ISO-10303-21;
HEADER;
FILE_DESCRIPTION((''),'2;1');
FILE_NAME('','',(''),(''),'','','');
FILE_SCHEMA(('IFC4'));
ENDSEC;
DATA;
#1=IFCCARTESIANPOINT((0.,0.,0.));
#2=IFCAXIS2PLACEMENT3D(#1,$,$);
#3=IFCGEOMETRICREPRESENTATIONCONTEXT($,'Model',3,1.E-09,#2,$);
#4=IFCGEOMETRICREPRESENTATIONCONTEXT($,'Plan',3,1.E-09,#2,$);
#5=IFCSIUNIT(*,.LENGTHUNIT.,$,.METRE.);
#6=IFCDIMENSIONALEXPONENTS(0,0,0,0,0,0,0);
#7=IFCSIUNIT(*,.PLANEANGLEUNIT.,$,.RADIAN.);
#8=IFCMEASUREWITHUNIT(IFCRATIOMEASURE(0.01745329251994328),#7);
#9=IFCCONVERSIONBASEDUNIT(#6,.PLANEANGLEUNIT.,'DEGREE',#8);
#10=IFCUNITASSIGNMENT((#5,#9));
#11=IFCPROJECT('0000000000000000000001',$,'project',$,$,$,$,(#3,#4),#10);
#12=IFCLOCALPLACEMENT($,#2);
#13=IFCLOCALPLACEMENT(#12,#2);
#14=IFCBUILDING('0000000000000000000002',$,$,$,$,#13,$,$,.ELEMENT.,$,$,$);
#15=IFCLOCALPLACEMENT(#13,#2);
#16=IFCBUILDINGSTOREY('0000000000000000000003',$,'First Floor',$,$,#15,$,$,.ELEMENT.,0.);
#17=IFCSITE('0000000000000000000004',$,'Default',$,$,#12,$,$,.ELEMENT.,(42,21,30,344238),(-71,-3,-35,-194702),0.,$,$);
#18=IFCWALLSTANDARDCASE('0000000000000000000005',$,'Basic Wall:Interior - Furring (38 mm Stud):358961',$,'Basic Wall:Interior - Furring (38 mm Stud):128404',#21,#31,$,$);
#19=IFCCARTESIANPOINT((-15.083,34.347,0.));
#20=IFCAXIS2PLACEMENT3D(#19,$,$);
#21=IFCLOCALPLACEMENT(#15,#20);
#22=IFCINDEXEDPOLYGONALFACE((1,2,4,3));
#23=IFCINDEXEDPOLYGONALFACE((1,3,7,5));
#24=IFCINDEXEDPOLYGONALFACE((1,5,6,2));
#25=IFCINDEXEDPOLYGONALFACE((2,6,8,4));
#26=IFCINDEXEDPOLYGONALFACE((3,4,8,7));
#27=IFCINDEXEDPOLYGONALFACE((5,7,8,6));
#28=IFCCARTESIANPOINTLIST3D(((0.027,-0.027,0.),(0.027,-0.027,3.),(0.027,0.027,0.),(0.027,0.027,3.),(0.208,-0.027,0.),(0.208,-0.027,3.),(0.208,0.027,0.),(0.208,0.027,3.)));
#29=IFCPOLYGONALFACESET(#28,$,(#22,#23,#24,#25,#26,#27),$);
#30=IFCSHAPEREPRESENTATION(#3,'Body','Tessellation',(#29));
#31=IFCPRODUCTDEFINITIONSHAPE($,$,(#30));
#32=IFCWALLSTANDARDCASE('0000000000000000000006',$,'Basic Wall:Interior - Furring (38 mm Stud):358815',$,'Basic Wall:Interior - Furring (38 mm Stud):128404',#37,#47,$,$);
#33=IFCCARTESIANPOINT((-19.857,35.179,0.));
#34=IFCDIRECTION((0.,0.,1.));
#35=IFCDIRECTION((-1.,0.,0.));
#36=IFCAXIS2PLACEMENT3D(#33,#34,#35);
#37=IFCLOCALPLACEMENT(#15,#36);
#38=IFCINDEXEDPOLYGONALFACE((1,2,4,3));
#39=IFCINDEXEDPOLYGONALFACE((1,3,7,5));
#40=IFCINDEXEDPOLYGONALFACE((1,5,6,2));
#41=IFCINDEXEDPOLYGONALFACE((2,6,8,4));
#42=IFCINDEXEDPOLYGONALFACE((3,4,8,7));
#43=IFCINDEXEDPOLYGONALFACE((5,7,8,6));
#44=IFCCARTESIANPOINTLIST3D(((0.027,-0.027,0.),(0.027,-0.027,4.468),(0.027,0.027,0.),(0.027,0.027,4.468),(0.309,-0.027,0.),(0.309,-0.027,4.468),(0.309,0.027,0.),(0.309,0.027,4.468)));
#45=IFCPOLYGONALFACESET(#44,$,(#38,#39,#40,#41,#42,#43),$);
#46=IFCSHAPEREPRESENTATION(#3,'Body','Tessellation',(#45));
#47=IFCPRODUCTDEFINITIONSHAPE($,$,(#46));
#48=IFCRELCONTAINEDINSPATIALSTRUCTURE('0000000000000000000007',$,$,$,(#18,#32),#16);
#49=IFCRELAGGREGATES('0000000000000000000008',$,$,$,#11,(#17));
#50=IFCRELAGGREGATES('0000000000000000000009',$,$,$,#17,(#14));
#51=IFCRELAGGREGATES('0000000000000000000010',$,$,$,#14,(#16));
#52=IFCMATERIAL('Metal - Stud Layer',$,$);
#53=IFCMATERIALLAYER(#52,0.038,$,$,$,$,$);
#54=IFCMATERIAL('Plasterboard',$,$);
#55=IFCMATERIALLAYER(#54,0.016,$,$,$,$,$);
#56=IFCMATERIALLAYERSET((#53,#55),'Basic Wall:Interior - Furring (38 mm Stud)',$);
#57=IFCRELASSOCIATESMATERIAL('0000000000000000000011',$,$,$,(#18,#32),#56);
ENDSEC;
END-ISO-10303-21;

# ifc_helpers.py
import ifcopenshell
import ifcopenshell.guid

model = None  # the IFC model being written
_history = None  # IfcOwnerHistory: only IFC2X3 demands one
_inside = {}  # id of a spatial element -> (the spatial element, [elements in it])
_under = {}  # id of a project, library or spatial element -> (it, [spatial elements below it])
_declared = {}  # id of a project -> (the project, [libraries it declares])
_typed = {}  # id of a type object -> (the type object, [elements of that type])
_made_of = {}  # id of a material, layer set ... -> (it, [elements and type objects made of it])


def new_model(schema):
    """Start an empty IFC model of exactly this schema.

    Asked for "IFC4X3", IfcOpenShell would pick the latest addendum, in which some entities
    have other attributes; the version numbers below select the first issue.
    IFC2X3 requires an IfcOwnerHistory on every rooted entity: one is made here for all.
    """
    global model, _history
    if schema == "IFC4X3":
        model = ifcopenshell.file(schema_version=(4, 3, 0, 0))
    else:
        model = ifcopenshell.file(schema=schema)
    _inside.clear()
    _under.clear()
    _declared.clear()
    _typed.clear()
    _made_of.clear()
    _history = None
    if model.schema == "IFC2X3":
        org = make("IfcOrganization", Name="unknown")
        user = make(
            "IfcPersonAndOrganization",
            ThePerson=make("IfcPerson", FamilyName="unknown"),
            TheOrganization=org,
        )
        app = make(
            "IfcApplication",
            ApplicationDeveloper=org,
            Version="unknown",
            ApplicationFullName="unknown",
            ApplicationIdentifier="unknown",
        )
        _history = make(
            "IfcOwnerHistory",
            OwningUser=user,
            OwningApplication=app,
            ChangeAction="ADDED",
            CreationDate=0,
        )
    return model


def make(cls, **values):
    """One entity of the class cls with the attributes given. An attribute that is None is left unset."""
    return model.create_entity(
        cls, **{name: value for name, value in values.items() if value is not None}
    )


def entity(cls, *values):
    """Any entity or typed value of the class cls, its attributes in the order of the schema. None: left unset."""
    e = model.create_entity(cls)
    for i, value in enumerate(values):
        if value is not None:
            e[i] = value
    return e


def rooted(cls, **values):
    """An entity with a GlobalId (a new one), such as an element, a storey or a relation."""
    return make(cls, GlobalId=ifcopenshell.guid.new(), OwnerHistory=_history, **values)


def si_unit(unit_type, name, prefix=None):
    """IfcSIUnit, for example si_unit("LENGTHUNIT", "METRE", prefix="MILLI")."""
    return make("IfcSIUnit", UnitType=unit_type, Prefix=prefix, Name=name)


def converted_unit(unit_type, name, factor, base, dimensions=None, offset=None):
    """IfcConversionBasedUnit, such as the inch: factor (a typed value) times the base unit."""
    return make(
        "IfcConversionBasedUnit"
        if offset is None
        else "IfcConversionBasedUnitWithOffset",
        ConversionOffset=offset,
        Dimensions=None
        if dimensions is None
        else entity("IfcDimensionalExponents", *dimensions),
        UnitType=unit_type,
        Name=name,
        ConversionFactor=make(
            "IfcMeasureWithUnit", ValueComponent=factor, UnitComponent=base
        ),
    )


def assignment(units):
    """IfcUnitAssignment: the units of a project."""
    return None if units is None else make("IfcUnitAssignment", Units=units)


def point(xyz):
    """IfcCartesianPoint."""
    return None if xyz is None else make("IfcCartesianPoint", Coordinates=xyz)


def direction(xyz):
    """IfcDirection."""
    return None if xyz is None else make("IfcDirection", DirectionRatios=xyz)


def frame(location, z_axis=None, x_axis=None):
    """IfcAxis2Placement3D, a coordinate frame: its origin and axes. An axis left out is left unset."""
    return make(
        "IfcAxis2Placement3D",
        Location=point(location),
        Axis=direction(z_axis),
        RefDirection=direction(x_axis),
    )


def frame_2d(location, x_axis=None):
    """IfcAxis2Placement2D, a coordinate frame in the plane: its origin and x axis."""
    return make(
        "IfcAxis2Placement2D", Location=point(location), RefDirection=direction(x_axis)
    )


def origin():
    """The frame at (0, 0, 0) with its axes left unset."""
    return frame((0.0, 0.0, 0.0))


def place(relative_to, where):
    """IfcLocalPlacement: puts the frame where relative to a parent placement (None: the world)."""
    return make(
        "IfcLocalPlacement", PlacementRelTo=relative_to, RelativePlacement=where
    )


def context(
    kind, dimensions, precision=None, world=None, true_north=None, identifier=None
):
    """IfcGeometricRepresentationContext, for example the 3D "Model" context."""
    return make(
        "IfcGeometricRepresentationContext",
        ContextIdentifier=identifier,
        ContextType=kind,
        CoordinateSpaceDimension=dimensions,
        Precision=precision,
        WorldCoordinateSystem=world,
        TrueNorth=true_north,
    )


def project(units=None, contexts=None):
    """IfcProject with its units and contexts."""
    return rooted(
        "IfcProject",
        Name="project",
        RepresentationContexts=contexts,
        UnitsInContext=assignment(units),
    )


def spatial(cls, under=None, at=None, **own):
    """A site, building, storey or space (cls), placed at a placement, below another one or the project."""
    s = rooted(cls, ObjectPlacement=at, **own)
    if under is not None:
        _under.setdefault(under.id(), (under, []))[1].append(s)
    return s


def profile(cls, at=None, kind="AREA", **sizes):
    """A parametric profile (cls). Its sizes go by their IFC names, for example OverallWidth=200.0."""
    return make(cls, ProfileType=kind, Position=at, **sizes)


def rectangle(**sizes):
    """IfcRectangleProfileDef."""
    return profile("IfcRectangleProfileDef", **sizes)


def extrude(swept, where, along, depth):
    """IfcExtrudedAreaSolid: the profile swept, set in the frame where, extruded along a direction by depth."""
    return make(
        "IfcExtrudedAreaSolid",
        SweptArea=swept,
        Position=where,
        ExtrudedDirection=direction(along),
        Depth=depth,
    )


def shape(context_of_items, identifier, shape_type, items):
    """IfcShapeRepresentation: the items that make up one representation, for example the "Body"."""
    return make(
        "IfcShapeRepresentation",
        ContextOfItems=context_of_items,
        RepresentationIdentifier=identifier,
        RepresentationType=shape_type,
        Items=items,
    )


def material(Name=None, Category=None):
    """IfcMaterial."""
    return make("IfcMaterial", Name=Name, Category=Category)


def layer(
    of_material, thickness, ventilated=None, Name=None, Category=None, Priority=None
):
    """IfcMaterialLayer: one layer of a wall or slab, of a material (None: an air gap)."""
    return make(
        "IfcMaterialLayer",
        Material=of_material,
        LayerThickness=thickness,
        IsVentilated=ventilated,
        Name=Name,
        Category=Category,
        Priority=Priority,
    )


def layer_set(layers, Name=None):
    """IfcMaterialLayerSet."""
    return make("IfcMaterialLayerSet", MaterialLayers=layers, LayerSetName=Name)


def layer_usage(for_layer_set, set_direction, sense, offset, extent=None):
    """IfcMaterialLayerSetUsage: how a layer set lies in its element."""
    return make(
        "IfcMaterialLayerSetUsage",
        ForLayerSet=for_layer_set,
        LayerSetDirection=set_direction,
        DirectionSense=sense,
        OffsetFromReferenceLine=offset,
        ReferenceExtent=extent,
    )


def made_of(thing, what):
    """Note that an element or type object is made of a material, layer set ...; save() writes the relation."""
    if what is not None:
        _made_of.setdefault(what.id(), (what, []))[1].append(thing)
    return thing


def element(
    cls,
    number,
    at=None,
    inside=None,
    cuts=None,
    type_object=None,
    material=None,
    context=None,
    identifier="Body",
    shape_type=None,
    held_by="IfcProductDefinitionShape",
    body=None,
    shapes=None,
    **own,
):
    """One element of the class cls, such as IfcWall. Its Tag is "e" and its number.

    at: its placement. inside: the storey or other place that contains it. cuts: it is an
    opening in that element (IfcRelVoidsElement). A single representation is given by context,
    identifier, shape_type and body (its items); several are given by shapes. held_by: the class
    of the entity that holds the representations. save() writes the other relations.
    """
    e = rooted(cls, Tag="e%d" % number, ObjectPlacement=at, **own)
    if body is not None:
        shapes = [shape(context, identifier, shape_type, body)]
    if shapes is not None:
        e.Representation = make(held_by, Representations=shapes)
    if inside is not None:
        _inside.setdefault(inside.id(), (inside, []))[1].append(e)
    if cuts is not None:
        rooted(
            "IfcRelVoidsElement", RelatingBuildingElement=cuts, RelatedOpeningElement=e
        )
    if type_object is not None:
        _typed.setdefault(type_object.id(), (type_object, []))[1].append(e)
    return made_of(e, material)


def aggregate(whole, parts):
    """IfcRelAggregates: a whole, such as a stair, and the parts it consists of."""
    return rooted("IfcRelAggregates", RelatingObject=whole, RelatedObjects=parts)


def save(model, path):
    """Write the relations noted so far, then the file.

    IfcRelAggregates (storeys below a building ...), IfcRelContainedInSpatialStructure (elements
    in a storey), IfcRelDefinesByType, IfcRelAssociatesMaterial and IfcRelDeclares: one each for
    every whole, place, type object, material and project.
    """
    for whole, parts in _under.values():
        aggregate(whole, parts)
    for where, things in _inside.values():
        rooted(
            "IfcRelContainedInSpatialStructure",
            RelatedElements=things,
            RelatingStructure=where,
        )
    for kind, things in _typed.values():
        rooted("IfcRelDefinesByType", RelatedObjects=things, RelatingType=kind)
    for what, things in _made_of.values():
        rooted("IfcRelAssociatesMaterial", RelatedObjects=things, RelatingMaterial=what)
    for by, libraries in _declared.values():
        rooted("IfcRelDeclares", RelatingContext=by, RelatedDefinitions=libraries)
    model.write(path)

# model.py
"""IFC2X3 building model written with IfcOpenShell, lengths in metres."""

from ifc_helpers import new_model, entity, si_unit, converted_unit, frame, frame_2d, origin, place, context, project, spatial, rectangle, extrude, material, layer, layer_set, layer_usage, element, save


model = new_model("IFC2X3")

# Units and contexts
model_context = context("Model", 3, precision=1e-09, world=origin())
plan_context = context("Plan", 3, precision=1e-09, world=origin())
ifc_project = project(units=[si_unit("LENGTHUNIT", "METRE"), converted_unit("PLANEANGLEUNIT", "DEGREE", entity("IfcRatioMeasure", 0.01745329251994328), si_unit("PLANEANGLEUNIT", "RADIAN"), dimensions=[0, 0, 0, 0, 0, 0, 0])], contexts=[model_context, plan_context])

# Site, building, storey
site_placement = place(None, origin())
site = spatial("IfcSite", under=ifc_project, at=site_placement, Name="Default", CompositionType="ELEMENT", RefLatitude=(42, 21, 30, 344238), RefLongitude=(-71, -3, -35, -194702), RefElevation=0.0)
building_placement = place(site_placement, origin())
building = spatial("IfcBuilding", under=site, at=building_placement, CompositionType="ELEMENT")
storey_placement = place(building_placement, origin())
storey = spatial("IfcBuildingStorey", under=building, at=storey_placement, Name="First Floor", CompositionType="ELEMENT", Elevation=0.0)

# Shared definitions
ifc_material_1 = material(Name="Plasterboard")
ifc_layer_1 = layer(ifc_material_1, 0.016)
ifc_material_2 = material(Name="Metal - Stud Layer")

# Walls
ifc_layer_2 = layer(ifc_material_2, 0.038)
ifc_layer_set_1 = layer_set([ifc_layer_2, ifc_layer_1], Name="Basic Wall:Interior - Furring (38 mm Stud)")
ifc_layer_usage_1 = layer_usage(ifc_layer_set_1, "AXIS2", "NEGATIVE", 0.027)
wall_1_placement = place(storey_placement, frame((-15.083, 34.347, 0.0)))
element("IfcWallStandardCase", 1, at=wall_1_placement, inside=storey, material=ifc_layer_usage_1, Name="Basic Wall:Interior - Furring (38 mm Stud):358961", ObjectType="Basic Wall:Interior - Furring (38 mm Stud):128404", context=model_context, shape_type="SweptSolid", body=[
    extrude(rectangle(XDim=0.181, YDim=0.054, at=frame_2d((0.1175, 0.0), x_axis=(-1.0, 0.0))), origin(), (0.0, 0.0, 1.0), 3.0),
])
wall_2_placement = place(storey_placement, frame((-19.857, 35.179, 0.0), z_axis=(0.0, 0.0, 1.0), x_axis=(-1.0, 0.0, 0.0)))
element("IfcWallStandardCase", 2, at=wall_2_placement, inside=storey, material=ifc_layer_usage_1, Name="Basic Wall:Interior - Furring (38 mm Stud):358815", ObjectType="Basic Wall:Interior - Furring (38 mm Stud):128404", context=model_context, shape_type="SweptSolid", body=[
    extrude(rectangle(XDim=0.282, YDim=0.054, at=frame_2d((0.168, 0.0), x_axis=(-1.0, 0.0))), origin(), (0.0, 0.0, 1.0), 4.468),
])

save(model, "model.ifc")
